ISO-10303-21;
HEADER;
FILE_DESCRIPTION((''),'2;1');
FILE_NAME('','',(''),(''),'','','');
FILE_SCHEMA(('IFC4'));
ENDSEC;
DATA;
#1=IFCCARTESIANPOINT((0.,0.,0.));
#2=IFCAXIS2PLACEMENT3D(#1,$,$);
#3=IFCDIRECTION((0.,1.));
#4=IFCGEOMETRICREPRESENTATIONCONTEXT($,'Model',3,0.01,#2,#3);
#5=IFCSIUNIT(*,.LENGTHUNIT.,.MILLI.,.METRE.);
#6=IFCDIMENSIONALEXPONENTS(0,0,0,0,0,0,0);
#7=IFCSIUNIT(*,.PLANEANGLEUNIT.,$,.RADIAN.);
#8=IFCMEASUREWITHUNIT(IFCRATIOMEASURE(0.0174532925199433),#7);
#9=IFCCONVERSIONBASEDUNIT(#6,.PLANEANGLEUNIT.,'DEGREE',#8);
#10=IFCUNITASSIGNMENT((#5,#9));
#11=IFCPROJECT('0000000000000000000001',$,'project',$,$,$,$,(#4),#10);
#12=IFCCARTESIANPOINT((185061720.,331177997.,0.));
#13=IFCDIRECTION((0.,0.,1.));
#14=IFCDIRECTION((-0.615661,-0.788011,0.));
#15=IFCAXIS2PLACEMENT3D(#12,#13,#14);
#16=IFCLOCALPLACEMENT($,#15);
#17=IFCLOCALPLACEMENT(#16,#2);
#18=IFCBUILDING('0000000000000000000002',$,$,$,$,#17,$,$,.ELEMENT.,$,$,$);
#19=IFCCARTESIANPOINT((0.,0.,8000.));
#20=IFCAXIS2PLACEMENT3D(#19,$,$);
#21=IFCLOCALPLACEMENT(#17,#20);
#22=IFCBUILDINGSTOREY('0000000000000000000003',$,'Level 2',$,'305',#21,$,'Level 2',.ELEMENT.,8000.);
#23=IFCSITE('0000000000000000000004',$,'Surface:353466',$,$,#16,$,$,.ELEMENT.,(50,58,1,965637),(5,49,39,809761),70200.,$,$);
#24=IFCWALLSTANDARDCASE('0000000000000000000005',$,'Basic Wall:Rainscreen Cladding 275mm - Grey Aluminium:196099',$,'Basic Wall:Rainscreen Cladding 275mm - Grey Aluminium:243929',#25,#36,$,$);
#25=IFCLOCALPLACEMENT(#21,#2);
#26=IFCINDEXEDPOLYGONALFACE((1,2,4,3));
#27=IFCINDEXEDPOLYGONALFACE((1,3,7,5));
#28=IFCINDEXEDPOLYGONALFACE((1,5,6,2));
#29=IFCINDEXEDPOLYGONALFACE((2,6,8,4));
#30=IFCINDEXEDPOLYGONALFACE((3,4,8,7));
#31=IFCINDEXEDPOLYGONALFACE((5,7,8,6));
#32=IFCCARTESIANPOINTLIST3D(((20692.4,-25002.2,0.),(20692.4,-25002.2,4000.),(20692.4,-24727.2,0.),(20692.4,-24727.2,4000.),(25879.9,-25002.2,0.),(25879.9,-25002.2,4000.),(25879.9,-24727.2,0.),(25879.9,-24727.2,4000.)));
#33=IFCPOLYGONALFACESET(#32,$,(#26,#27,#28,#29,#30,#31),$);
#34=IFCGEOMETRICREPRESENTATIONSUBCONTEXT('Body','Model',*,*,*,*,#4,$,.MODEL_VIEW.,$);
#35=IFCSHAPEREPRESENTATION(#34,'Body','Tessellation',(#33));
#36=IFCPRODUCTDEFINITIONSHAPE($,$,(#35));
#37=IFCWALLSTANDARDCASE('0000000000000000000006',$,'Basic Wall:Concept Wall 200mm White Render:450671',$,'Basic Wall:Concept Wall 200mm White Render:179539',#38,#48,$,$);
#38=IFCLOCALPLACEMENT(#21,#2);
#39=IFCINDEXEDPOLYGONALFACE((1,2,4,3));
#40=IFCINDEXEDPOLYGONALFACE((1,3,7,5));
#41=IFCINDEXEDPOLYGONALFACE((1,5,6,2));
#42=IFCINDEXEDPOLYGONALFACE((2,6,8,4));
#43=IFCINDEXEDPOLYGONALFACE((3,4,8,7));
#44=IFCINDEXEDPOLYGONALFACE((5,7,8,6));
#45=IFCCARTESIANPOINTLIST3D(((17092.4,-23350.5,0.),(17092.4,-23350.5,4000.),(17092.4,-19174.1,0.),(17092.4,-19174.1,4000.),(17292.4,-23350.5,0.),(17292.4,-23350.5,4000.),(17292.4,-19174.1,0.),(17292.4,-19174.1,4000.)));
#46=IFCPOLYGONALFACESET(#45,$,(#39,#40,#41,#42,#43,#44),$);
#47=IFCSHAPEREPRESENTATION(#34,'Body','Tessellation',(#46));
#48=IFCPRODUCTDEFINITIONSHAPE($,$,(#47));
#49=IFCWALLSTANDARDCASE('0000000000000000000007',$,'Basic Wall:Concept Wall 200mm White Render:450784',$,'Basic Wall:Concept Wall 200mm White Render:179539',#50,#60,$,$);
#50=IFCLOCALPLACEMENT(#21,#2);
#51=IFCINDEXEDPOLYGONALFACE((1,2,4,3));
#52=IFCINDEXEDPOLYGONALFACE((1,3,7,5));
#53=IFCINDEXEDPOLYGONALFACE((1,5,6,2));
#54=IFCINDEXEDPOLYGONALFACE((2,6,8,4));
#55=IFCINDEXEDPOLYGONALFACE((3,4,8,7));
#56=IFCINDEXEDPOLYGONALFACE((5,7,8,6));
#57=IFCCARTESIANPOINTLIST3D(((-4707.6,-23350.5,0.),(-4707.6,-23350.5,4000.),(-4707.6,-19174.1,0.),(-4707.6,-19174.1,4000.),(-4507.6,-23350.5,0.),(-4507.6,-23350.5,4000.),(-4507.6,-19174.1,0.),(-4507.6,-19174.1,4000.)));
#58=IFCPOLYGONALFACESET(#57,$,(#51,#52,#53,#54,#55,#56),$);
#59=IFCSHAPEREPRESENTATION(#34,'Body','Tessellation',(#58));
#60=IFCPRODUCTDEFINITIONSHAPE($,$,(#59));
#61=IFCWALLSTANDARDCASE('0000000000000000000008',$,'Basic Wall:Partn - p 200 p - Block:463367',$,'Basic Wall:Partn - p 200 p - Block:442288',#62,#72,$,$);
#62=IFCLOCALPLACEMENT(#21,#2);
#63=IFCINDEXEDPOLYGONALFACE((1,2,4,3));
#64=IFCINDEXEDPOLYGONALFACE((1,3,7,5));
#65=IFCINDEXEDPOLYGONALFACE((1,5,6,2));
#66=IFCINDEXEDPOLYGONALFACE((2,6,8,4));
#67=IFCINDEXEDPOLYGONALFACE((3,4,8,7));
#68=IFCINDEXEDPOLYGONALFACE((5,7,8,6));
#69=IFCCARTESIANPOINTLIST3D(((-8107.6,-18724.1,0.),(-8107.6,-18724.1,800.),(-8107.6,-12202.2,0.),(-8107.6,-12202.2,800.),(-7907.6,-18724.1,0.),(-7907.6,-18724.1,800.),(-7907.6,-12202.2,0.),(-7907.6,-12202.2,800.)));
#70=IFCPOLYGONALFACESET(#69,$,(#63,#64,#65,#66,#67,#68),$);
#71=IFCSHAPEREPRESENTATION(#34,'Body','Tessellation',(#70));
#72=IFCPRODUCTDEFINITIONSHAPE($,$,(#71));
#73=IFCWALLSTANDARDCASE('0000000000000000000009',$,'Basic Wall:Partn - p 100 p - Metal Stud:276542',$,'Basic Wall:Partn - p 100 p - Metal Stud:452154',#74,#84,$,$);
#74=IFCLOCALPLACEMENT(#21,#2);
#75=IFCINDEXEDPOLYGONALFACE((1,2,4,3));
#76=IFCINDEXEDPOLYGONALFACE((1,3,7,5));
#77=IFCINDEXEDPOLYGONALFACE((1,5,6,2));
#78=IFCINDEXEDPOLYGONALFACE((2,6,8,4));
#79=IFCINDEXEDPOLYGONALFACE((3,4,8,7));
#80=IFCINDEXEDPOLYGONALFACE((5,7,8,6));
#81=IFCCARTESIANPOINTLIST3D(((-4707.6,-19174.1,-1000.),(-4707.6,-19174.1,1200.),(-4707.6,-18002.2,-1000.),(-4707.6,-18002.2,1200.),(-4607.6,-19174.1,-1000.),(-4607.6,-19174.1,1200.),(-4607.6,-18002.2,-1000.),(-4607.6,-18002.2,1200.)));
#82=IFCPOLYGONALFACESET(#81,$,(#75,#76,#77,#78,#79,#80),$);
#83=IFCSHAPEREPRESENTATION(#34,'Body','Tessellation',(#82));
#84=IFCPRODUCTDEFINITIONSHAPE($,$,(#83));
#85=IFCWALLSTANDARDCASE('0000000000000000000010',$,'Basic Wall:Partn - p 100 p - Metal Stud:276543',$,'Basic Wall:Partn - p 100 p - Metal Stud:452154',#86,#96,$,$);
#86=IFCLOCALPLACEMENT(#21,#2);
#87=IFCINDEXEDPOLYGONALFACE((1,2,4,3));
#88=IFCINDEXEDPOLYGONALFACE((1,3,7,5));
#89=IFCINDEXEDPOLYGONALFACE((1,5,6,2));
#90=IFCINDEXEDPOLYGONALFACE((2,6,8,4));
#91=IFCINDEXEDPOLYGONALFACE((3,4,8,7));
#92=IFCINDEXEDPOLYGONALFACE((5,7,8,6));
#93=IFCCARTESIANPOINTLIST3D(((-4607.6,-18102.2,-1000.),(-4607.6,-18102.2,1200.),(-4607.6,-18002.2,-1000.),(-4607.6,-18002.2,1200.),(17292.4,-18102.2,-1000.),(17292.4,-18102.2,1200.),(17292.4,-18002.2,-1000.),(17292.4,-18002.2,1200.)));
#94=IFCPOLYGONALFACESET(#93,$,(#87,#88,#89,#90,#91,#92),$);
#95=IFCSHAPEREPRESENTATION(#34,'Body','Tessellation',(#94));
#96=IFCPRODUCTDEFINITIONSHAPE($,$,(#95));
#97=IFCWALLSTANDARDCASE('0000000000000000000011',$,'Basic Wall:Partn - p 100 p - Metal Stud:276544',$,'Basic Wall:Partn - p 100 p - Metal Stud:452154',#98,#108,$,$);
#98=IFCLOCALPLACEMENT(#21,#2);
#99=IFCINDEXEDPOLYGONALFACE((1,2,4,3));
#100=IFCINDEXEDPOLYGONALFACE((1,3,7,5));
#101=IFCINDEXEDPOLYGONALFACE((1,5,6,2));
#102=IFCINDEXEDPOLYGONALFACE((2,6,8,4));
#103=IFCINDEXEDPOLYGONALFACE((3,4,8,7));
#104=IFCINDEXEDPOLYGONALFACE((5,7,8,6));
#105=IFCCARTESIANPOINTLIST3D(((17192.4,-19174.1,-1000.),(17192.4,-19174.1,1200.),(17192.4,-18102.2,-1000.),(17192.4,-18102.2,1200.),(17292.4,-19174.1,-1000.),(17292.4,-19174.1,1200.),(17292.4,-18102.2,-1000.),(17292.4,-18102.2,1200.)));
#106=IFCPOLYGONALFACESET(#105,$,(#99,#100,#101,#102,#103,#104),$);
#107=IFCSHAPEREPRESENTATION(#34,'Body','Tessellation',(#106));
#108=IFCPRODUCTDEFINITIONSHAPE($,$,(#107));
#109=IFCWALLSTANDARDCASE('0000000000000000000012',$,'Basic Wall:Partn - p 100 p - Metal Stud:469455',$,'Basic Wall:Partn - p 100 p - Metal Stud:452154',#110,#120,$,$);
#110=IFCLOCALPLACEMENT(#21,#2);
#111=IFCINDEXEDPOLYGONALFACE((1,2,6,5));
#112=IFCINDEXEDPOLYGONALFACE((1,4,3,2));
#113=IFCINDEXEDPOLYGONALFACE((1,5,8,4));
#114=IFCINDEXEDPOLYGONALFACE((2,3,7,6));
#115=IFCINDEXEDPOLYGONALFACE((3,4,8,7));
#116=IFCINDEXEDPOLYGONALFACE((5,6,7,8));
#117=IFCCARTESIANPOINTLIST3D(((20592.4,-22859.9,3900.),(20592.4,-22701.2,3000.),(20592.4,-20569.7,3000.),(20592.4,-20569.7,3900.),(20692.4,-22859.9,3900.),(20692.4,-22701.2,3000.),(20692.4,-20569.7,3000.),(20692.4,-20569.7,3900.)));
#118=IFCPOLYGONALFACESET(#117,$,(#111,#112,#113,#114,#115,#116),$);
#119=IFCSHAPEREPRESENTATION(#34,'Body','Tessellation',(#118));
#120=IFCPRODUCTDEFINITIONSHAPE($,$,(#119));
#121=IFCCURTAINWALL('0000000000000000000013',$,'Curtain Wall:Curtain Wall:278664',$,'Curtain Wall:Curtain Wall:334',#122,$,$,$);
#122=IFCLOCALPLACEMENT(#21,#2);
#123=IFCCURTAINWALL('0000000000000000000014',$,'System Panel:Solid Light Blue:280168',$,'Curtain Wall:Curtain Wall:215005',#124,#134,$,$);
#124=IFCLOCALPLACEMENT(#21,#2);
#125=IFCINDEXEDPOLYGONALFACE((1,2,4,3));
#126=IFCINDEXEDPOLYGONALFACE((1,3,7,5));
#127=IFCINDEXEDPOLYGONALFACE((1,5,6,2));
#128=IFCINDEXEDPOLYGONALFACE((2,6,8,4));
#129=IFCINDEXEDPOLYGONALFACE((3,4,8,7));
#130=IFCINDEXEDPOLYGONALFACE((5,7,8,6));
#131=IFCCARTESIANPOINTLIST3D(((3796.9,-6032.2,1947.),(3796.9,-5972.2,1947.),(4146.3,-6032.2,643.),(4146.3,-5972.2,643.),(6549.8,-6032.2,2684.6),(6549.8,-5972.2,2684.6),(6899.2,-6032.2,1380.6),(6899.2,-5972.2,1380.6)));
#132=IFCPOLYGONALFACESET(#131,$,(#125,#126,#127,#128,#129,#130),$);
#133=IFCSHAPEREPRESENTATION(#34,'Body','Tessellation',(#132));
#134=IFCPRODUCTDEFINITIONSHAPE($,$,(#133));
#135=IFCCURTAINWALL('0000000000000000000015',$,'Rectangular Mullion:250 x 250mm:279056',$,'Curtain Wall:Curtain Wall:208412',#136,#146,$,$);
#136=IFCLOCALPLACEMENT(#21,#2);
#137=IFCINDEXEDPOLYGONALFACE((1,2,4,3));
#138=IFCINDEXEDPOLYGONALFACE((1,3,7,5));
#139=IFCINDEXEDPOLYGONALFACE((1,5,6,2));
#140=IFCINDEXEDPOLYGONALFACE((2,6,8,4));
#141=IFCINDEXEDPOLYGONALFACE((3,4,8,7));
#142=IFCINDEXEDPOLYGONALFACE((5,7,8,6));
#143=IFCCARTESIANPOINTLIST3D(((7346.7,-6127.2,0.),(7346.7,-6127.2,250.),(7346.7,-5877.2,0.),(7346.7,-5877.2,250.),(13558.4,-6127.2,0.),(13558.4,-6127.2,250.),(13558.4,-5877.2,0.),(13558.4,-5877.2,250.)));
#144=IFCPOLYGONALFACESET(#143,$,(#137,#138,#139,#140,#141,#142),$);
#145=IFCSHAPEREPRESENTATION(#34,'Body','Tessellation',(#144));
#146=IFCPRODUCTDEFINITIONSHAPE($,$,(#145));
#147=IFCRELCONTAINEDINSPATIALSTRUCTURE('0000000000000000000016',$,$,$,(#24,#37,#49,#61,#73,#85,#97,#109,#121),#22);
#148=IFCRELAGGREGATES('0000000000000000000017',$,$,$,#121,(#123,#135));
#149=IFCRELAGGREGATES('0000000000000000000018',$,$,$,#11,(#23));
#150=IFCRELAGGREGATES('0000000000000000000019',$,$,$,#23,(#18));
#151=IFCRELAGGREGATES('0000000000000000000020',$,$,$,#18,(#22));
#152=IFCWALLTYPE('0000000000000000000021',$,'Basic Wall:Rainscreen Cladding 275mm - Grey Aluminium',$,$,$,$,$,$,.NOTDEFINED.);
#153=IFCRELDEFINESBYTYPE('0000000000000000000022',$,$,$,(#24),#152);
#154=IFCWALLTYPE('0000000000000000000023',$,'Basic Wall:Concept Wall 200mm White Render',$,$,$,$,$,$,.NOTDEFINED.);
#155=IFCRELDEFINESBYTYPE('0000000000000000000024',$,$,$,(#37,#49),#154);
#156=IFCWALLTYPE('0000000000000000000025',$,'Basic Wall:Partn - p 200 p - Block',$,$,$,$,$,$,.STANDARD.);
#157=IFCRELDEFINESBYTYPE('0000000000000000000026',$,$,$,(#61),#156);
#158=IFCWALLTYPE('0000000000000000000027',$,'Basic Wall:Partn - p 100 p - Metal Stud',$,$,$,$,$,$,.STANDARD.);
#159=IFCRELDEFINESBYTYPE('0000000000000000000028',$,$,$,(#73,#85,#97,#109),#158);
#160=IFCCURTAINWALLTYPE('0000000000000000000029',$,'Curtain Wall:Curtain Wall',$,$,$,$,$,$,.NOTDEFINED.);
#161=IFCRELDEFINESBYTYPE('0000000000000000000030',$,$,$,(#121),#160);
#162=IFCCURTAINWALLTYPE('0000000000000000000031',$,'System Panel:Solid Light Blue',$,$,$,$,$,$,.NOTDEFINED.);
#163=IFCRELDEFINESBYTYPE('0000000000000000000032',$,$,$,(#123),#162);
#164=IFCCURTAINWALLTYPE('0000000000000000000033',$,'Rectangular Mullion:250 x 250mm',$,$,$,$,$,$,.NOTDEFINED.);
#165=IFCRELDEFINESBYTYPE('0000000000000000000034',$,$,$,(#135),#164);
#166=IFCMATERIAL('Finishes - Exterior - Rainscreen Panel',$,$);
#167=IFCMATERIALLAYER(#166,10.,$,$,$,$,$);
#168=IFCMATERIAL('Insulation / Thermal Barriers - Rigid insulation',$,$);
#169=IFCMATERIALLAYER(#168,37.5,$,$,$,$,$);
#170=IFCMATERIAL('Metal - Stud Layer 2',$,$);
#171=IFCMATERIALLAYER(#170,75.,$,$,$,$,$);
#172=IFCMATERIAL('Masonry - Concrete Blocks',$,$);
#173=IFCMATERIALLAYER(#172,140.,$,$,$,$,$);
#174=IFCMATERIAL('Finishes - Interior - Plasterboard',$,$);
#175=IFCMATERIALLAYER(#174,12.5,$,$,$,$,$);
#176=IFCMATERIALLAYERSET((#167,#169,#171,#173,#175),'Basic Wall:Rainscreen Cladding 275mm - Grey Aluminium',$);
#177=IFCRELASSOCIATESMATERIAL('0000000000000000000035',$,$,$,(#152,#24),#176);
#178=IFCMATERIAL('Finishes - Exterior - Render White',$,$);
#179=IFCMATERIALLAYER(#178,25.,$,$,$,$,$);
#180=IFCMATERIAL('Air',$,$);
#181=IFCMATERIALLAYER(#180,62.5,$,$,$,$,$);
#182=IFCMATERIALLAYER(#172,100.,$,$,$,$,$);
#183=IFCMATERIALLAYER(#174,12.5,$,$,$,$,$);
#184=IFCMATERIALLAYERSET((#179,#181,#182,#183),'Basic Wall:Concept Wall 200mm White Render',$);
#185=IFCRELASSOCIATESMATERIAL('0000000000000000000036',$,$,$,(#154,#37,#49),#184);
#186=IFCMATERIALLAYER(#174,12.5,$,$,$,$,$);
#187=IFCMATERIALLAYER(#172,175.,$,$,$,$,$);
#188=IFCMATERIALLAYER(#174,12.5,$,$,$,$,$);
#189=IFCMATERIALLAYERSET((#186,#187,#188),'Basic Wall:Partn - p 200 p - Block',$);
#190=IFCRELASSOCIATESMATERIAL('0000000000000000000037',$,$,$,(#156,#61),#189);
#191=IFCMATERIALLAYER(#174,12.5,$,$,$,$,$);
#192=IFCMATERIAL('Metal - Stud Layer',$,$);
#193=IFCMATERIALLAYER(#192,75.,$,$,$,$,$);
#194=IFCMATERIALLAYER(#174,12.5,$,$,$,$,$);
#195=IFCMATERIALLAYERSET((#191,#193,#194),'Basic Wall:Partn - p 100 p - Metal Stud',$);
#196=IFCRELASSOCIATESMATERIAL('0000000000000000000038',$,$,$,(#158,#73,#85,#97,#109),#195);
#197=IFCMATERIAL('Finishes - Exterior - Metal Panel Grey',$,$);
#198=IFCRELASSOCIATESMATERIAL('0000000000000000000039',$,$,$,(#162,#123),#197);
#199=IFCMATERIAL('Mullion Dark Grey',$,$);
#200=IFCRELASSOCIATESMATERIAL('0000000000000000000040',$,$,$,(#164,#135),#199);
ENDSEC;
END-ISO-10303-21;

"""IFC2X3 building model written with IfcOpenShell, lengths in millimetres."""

from ifc_helpers import new_model, entity, si_unit, converted_unit, direction, frame, frame_2d, origin, origin_2d_with_axis, place, context, subcontext, project, spatial, rectangle, extrude, clip, halfspace, source, transform, mapped, material, layer, layer_set, layer_usage, type_object, type_shapes, element, aggregate, save


model = new_model("IFC2X3")

# Units and contexts
model_context = context("Model", 3, precision=0.01, world=origin(), true_north=direction((0.0, 1.0)))
body_context = subcontext(model_context, "Body", "Model", "MODEL_VIEW")
ifc_project = project(units=[si_unit("LENGTHUNIT", "METRE", prefix="MILLI"), converted_unit("PLANEANGLEUNIT", "DEGREE", entity("IfcRatioMeasure", 0.0174532925199433), si_unit("PLANEANGLEUNIT", "RADIAN"), dimensions=[0, 0, 0, 0, 0, 0, 0])], contexts=[model_context])

# Site, building, storey
site_placement = place(None, frame((185061720.0, 331177997.0, 0.0), z_axis=(0.0, 0.0, 1.0), x_axis=(-0.615661, -0.788011, 0.0)))
site = spatial("IfcSite", under=ifc_project, at=site_placement, Name="Surface:353466", CompositionType="ELEMENT", RefLatitude=(50, 58, 1, 965637), RefLongitude=(5, 49, 39, 809761), RefElevation=70200.0)
building_placement = place(site_placement, origin())
building = spatial("IfcBuilding", under=site, at=building_placement, CompositionType="ELEMENT")
storey_placement = place(building_placement, frame((0.0, 0.0, 8000.0)))
storey = spatial("IfcBuildingStorey", under=building, at=storey_placement, Name="Level 2", ObjectType="305", LongName="Level 2", CompositionType="ELEMENT", Elevation=8000.0)

# Walls
ifc_material_1 = material(Name="Finishes - Exterior - Rainscreen Panel")
ifc_layer_1 = layer(ifc_material_1, 10.0)
ifc_material_2 = material(Name="Insulation / Thermal Barriers - Rigid insulation")
ifc_layer_2 = layer(ifc_material_2, 37.5)
ifc_material_3 = material(Name="Metal - Stud Layer 2")
ifc_layer_3 = layer(ifc_material_3, 75.0)
ifc_material_4 = material(Name="Masonry - Concrete Blocks")
ifc_layer_4 = layer(ifc_material_4, 140.0)
ifc_material_5 = material(Name="Finishes - Interior - Plasterboard")
ifc_layer_5 = layer(ifc_material_5, 12.5)
ifc_layer_set_1 = layer_set([ifc_layer_1, ifc_layer_2, ifc_layer_3, ifc_layer_4, ifc_layer_5], Name="Basic Wall:Rainscreen Cladding 275mm - Grey Aluminium")
ifc_layer_usage_1 = layer_usage(ifc_layer_set_1, "AXIS2", "POSITIVE", -137.5)
wall_type_1 = type_object("IfcWallType", Name="Basic Wall:Rainscreen Cladding 275mm - Grey Aluminium", PredefinedType="NOTDEFINED", material=ifc_layer_set_1)
wall_1_placement = place(storey_placement, frame((20692.4, -24864.7, 0.0)))
element("IfcWallStandardCase", 1, at=wall_1_placement, inside=storey, type_object=wall_type_1, material=ifc_layer_usage_1, Name="Basic Wall:Rainscreen Cladding 275mm - Grey Aluminium:196099", ObjectType="Basic Wall:Rainscreen Cladding 275mm - Grey Aluminium:243929", context=body_context, shape_type="Clipping", body=[
    clip(extrude(rectangle(XDim=5187.5, YDim=275.0, at=frame_2d((2593.8, 0.0), x_axis=(-1.0, 0.0))), origin(), (0.0, 0.0, 1.0), 4000.0), halfspace(frame((0.0, 0.0, -8000.0)), True)),
])
ifc_material_6 = material(Name="Finishes - Exterior - Render White")
ifc_layer_6 = layer(ifc_material_6, 25.0)
ifc_material_7 = material(Name="Air")
ifc_layer_7 = layer(ifc_material_7, 62.5)
ifc_layer_8 = layer(ifc_material_4, 100.0)
ifc_layer_9 = layer(ifc_material_5, 12.5)
ifc_layer_set_2 = layer_set([ifc_layer_6, ifc_layer_7, ifc_layer_8, ifc_layer_9], Name="Basic Wall:Concept Wall 200mm White Render")
ifc_layer_usage_2 = layer_usage(ifc_layer_set_2, "AXIS2", "NEGATIVE", 100.0)
wall_type_2 = type_object("IfcWallType", Name="Basic Wall:Concept Wall 200mm White Render", PredefinedType="NOTDEFINED", material=ifc_layer_set_2)
wall_2_placement = place(storey_placement, frame((17192.4, -23350.5, 0.0), z_axis=(0.0, 0.0, 1.0), x_axis=(0.0, 1.0, 0.0)))
element("IfcWallStandardCase", 2, at=wall_2_placement, inside=storey, type_object=wall_type_2, material=ifc_layer_usage_2, Name="Basic Wall:Concept Wall 200mm White Render:450671", ObjectType="Basic Wall:Concept Wall 200mm White Render:179539", context=body_context, shape_type="Clipping", body=[
    clip(extrude(rectangle(XDim=4176.4, YDim=200.0, at=frame_2d((2088.2, 0.0), x_axis=(-1.0, 0.0))), origin(), (0.0, 0.0, 1.0), 4000.0), halfspace(frame((0.0, 0.0, -4000.0)), True)),
])
ifc_layer_usage_3 = layer_usage(ifc_layer_set_2, "AXIS2", "POSITIVE", -100.0)
wall_3_placement = place(storey_placement, frame((-4607.6, -23350.5, 0.0), z_axis=(0.0, 0.0, 1.0), x_axis=(0.0, 1.0, 0.0)))
element("IfcWallStandardCase", 3, at=wall_3_placement, inside=storey, type_object=wall_type_2, material=ifc_layer_usage_3, Name="Basic Wall:Concept Wall 200mm White Render:450784", ObjectType="Basic Wall:Concept Wall 200mm White Render:179539", context=body_context, shape_type="Clipping", body=[
    clip(extrude(rectangle(XDim=4176.4, YDim=200.0, at=frame_2d((2088.2, 0.0), x_axis=(-1.0, 0.0))), origin(), (0.0, 0.0, 1.0), 4000.0), halfspace(frame((0.0, 0.0, -4000.0)), True)),
])
ifc_layer_10 = layer(ifc_material_5, 12.5)
ifc_layer_11 = layer(ifc_material_4, 175.0)
ifc_layer_12 = layer(ifc_material_5, 12.5)
ifc_layer_set_3 = layer_set([ifc_layer_10, ifc_layer_11, ifc_layer_12], Name="Basic Wall:Partn - p 200 p - Block")
ifc_layer_usage_4 = layer_usage(ifc_layer_set_3, "AXIS2", "NEGATIVE", 100.0)
wall_type_3 = type_object("IfcWallType", Name="Basic Wall:Partn - p 200 p - Block", PredefinedType="STANDARD", material=ifc_layer_set_3)
wall_4_placement = place(storey_placement, frame((-8007.6, -18724.1, 0.0), z_axis=(0.0, 0.0, 1.0), x_axis=(0.0, 1.0, 0.0)))
element("IfcWallStandardCase", 4, at=wall_4_placement, inside=storey, type_object=wall_type_3, material=ifc_layer_usage_4, Name="Basic Wall:Partn - p 200 p - Block:463367", ObjectType="Basic Wall:Partn - p 200 p - Block:442288", context=body_context, shape_type="Clipping", body=[
    clip(extrude(rectangle(XDim=6521.9, YDim=200.0, at=frame_2d((3261.0, 0.0), x_axis=(-1.0, 0.0))), origin(), (0.0, 0.0, 1.0), 800.0), halfspace(frame((0.0, 0.0, -4000.0)), True)),
])
ifc_layer_13 = layer(ifc_material_5, 12.5)
ifc_material_8 = material(Name="Metal - Stud Layer")
ifc_layer_14 = layer(ifc_material_8, 75.0)
ifc_layer_15 = layer(ifc_material_5, 12.5)
ifc_layer_set_4 = layer_set([ifc_layer_13, ifc_layer_14, ifc_layer_15], Name="Basic Wall:Partn - p 100 p - Metal Stud")
ifc_layer_usage_5 = layer_usage(ifc_layer_set_4, "AXIS2", "POSITIVE", -50.0)
wall_type_4 = type_object("IfcWallType", Name="Basic Wall:Partn - p 100 p - Metal Stud", PredefinedType="STANDARD", material=ifc_layer_set_4)
wall_5_placement = place(storey_placement, frame((-4657.6, -19174.1, -1000.0), z_axis=(0.0, 0.0, 1.0), x_axis=(0.0, 1.0, 0.0)))
element("IfcWallStandardCase", 5, at=wall_5_placement, inside=storey, type_object=wall_type_4, material=ifc_layer_usage_5, Name="Basic Wall:Partn - p 100 p - Metal Stud:276542", ObjectType="Basic Wall:Partn - p 100 p - Metal Stud:452154", context=body_context, shape_type="SweptSolid", body=[
    extrude(rectangle(XDim=1171.9, YDim=100.0, at=frame_2d((586.0, 0.0), x_axis=(-1.0, 0.0))), origin(), (0.0, 0.0, 1.0), 2200.0),
])
ifc_layer_usage_6 = layer_usage(ifc_layer_set_4, "AXIS2", "POSITIVE", -50.0)
wall_6_placement = place(storey_placement, frame((-4607.6, -18052.2, -1000.0)))
element("IfcWallStandardCase", 6, at=wall_6_placement, inside=storey, type_object=wall_type_4, material=ifc_layer_usage_6, Name="Basic Wall:Partn - p 100 p - Metal Stud:276543", ObjectType="Basic Wall:Partn - p 100 p - Metal Stud:452154", context=body_context, shape_type="SweptSolid", body=[
    extrude(rectangle(XDim=21900.0, YDim=100.0, at=frame_2d((10950.0, 0.0), x_axis=(-1.0, 0.0))), origin(), (0.0, 0.0, 1.0), 2200.0),
])
ifc_layer_usage_7 = layer_usage(ifc_layer_set_4, "AXIS2", "POSITIVE", -50.0)
wall_7_placement = place(storey_placement, frame((17242.4, -18102.2, -1000.0), z_axis=(0.0, 0.0, 1.0), x_axis=(0.0, -1.0, 0.0)))
element("IfcWallStandardCase", 7, at=wall_7_placement, inside=storey, type_object=wall_type_4, material=ifc_layer_usage_7, Name="Basic Wall:Partn - p 100 p - Metal Stud:276544", ObjectType="Basic Wall:Partn - p 100 p - Metal Stud:452154", context=body_context, shape_type="SweptSolid", body=[
    extrude(rectangle(XDim=1071.9, YDim=100.0, at=frame_2d((536.0, 0.0), x_axis=(-1.0, 0.0))), origin(), (0.0, 0.0, 1.0), 2200.0),
])
ifc_layer_usage_8 = layer_usage(ifc_layer_set_4, "AXIS2", "POSITIVE", -50.0)
wall_8_placement = place(storey_placement, frame((20642.4, -20569.7, 3000.0), z_axis=(0.0, 0.0, 1.0), x_axis=(0.0, -1.0, 0.0)))
element("IfcWallStandardCase", 8, at=wall_8_placement, inside=storey, type_object=wall_type_4, material=ifc_layer_usage_8, Name="Basic Wall:Partn - p 100 p - Metal Stud:469455", ObjectType="Basic Wall:Partn - p 100 p - Metal Stud:452154", context=body_context, shape_type="Clipping", body=[
    clip(extrude(rectangle(XDim=2290.2, YDim=100.0, at=frame_2d((1145.1, 0.0), x_axis=(-1.0, 0.0))), origin(), (0.0, 0.0, 1.0), 900.0), halfspace(frame((2290.2, -50.0, 900.0), z_axis=(0.984808, 0.0, -0.173648), x_axis=(0.0, 1.0, 0.0)), False)),
])

# Curtain walls
curtain_wall_type_1 = type_object("IfcCurtainWallType", Name="Curtain Wall:Curtain Wall", PredefinedType="NOTDEFINED")
curtain_wall_1_placement = place(storey_placement, frame((0.0, 0.0, -8000.0)))
curtain_wall_1 = element("IfcCurtainWall", 9, at=curtain_wall_1_placement, inside=storey, type_object=curtain_wall_type_1, Name="Curtain Wall:Curtain Wall:278664", ObjectType="Curtain Wall:Curtain Wall:334")
ifc_material_9 = material(Name="Finishes - Exterior - Metal Panel Grey")
curtain_wall_type_2 = type_object("IfcCurtainWallType", Name="System Panel:Solid Light Blue", PredefinedType="NOTDEFINED", material=ifc_material_9)
shared_shape_1 = source(origin(), body_context, "Body", "SweptSolid", [
    extrude(rectangle(XDim=60.0, YDim=2850.0, at=frame_2d((0.0, 0.0), x_axis=(1.0, 0.0))), frame((0.0, 0.0, 0.0), z_axis=(0.0, 0.0, 1.0), x_axis=(0.0, 1.0, 0.0)), (0.0, 0.0, 1.0), 1350.0),
])
type_shapes(curtain_wall_type_2, [shared_shape_1])
curtain_wall_2_placement = place(storey_placement, frame((5522.7, -6002.2, 1011.8), z_axis=(-0.258819, 0.0, 0.965926), x_axis=(0.965926, 0.0, 0.258819)))
curtain_wall_2 = element("IfcCurtainWall", 10, at=curtain_wall_2_placement, type_object=curtain_wall_type_2, material=ifc_material_9, Name="System Panel:Solid Light Blue:280168", ObjectType="Curtain Wall:Curtain Wall:215005", context=body_context, shape_type="MappedRepresentation", body=[
    mapped(shared_shape_1, transform((0.0, 0.0, 0.0), scale=1.0)),
])
ifc_material_10 = material(Name="Mullion Dark Grey")
curtain_wall_type_3 = type_object("IfcCurtainWallType", Name="Rectangular Mullion:250 x 250mm", PredefinedType="NOTDEFINED", material=ifc_material_10)
shared_shape_2 = source(origin(), body_context, "Body", "SweptSolid", [
    extrude(rectangle(XDim=250.0, YDim=250.0, at=origin_2d_with_axis()), frame((-125.0, 0.0, -6211.7), z_axis=(0.0, 0.0, 1.0), x_axis=(-1.0, 0.0, 0.0)), (0.0, 0.0, 1.0), 6211.7),
])
type_shapes(curtain_wall_type_3, [shared_shape_2])
curtain_wall_3_placement = place(storey_placement, frame((7346.7, -6002.2, 0.0), z_axis=(-1.0, 0.0, 0.0), x_axis=(0.0, 0.0, -1.0)))
curtain_wall_3 = element("IfcCurtainWall", 11, at=curtain_wall_3_placement, type_object=curtain_wall_type_3, material=ifc_material_10, Name="Rectangular Mullion:250 x 250mm:279056", ObjectType="Curtain Wall:Curtain Wall:208412", context=body_context, shape_type="MappedRepresentation", body=[
    mapped(shared_shape_2, transform((0.0, 0.0, 0.0), scale=1.0)),
])
aggregate(curtain_wall_1, [curtain_wall_2, curtain_wall_3])

save(model, "model.ifc")
